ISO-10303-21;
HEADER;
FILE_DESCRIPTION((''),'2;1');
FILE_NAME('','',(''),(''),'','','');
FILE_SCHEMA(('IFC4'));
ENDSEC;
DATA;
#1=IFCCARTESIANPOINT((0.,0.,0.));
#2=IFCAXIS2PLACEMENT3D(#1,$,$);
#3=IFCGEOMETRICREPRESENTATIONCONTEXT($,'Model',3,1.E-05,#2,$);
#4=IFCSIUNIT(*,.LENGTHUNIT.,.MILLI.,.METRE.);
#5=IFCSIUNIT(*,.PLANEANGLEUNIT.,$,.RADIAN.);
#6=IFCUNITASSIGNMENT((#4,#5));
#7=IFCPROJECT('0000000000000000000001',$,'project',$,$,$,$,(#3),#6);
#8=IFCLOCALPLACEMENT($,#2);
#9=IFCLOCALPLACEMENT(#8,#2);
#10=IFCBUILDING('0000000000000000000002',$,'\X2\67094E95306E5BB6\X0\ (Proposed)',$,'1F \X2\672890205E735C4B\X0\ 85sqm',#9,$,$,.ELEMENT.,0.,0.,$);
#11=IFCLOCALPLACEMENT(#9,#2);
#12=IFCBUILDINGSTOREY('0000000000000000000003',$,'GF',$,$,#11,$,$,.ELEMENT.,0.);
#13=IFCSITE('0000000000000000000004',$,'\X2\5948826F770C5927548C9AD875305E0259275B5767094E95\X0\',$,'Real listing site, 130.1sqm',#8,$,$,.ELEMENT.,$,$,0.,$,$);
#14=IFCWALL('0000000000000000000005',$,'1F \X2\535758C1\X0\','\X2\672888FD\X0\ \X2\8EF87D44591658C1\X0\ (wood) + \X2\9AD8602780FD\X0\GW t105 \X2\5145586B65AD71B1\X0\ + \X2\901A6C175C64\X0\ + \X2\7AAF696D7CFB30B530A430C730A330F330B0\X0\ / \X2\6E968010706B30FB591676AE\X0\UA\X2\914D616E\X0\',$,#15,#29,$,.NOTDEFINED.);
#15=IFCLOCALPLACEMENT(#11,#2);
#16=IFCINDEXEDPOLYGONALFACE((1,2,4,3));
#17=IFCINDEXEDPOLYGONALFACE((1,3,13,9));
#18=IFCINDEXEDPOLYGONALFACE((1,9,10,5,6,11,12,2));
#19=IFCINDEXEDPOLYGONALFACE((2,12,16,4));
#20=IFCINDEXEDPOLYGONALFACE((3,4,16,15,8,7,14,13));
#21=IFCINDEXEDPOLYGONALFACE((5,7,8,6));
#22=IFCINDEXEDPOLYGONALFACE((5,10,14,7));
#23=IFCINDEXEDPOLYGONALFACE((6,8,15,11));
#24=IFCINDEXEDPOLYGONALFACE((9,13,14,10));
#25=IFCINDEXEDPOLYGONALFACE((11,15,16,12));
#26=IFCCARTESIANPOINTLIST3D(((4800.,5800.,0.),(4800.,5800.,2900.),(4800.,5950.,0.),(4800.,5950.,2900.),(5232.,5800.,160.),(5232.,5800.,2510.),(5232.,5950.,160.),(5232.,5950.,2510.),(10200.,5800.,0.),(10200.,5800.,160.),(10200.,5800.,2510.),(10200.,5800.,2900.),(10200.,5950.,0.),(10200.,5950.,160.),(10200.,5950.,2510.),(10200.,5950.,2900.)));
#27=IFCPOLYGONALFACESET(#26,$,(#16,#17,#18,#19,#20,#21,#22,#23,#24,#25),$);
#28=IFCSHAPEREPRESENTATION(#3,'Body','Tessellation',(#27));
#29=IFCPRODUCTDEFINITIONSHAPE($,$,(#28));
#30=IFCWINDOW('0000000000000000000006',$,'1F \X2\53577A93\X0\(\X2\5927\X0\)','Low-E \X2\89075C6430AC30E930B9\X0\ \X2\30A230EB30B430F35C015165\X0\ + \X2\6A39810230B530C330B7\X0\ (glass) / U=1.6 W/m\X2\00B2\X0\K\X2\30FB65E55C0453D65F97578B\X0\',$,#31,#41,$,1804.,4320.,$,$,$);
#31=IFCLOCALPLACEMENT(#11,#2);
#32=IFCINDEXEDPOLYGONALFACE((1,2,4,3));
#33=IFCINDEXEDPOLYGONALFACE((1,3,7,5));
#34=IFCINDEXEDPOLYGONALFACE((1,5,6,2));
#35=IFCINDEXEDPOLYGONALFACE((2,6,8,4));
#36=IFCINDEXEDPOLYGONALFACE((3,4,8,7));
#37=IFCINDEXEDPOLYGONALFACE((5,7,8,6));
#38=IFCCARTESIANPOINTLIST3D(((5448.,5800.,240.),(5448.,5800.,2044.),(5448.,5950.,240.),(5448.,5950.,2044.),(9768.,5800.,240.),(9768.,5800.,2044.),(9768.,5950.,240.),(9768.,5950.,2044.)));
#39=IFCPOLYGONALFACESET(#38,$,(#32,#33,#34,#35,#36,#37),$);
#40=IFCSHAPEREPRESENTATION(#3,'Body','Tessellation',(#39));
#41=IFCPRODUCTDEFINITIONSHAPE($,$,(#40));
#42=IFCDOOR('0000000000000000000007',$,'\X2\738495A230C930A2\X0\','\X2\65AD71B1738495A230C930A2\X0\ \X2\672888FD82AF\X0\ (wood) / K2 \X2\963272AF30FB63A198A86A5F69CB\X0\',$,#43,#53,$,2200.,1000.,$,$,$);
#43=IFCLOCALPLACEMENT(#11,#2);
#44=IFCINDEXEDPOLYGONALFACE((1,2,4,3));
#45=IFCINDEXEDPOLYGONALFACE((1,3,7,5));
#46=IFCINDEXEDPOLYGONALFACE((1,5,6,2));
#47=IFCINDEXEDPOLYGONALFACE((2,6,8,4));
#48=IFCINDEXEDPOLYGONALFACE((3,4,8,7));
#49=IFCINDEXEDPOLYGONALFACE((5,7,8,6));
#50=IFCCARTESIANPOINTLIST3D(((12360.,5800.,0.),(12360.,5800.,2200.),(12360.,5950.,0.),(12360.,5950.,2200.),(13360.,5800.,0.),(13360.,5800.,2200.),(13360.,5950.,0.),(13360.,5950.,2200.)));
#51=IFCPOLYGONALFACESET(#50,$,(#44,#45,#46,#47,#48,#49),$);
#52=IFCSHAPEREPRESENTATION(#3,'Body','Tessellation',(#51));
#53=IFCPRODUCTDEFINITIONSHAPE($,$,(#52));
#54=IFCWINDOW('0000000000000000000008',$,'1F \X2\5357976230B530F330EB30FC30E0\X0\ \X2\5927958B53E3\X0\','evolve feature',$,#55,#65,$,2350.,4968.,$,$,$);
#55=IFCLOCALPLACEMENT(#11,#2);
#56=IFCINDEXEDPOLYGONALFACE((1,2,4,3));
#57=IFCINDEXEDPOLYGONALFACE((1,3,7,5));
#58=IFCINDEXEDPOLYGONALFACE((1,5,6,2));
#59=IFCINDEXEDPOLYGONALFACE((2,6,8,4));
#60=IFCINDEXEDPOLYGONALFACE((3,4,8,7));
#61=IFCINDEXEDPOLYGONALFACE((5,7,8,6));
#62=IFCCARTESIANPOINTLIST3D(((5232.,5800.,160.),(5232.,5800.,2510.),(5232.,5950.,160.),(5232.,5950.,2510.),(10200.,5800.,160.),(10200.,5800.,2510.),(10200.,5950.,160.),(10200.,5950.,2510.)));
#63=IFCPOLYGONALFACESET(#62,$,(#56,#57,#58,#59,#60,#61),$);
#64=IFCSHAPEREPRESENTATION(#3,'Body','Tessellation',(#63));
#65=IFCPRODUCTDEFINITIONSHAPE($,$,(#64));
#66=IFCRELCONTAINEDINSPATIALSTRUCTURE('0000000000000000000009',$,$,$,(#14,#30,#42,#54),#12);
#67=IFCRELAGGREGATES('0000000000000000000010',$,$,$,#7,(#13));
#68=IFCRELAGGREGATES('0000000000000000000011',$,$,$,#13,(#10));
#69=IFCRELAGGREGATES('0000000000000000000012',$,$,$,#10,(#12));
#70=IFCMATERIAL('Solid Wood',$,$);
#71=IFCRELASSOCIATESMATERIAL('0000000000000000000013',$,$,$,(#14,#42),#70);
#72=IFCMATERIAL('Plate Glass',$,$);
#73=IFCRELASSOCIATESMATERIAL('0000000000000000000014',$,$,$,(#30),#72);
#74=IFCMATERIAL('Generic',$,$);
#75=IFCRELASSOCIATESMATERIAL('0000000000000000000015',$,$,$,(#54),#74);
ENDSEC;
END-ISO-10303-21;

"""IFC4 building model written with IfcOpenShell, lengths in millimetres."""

from ifc_helpers import new_model, si_unit, frame, frame_2d, origin, place, context, project, spatial, rectangle, extrude, material, element, fill, save


model = new_model("IFC4")

# Units and contexts
model_context = context("Model", 3, precision=1e-05, world=origin())
ifc_project = project(units=[si_unit("LENGTHUNIT", "METRE", prefix="MILLI"), si_unit("PLANEANGLEUNIT", "RADIAN")], contexts=[model_context])

# Site, building, storey
site_placement = place(None, origin())
site = spatial("IfcSite", under=ifc_project, at=site_placement, Name="奈良県大和高田市大字有井", ObjectType="Real listing site, 130.1sqm", CompositionType="ELEMENT", RefElevation=0.0)
building_placement = place(site_placement, origin())
building = spatial("IfcBuilding", under=site, at=building_placement, Name="有井の家 (Proposed)", ObjectType="1F 木造平屋 85sqm", CompositionType="ELEMENT", ElevationOfRefHeight=0.0, ElevationOfTerrain=0.0)
storey_placement = place(building_placement, origin())
storey = spatial("IfcBuildingStorey", under=building, at=storey_placement, Name="GF", CompositionType="ELEMENT", Elevation=0.0)

# Shared definitions
ifc_material_1 = material(Name="Solid Wood")
ifc_material_2 = material(Name="Generic")

# Wall, openings, windows, door
wall_1_placement = place(storey_placement, frame((2400.0, 2900.0, 0.0)))
wall_1 = element("IfcWall", 1, at=wall_1_placement, inside=storey, material=ifc_material_1, Name="1F 南壁", Description="木製 軸組外壁 (wood) + 高性能GW t105 充填断熱 + 通気層 + 窯業系サイディング / 準耐火・外皮UA配慮", PredefinedType="NOTDEFINED", context=model_context, shape_type="SweptSolid", body=[
    extrude(rectangle(XDim=5400.0, YDim=150.0, at=frame_2d((2700.0, 75.0))), frame((2400.0, 2900.0, 0.0)), (0.0, 0.0, 1.0), 2900.0),
])
opening_1_placement = place(storey_placement, frame((2724.0, 2900.0, 120.0)))
opening_1 = element("IfcOpeningElement", 2, at=opening_1_placement, cuts=wall_1, PredefinedType="NOTDEFINED", context=model_context, shape_type="SweptSolid", body=[
    extrude(rectangle(XDim=4320.0, YDim=150.0, at=frame_2d((2160.0, 75.0))), frame((2724.0, 2900.0, 120.0)), (0.0, 0.0, 1.0), 1804.0),
])
opening_2_placement = place(storey_placement, frame((6180.0, 2900.0, 0.0)))
opening_2 = element("IfcOpeningElement", 3, at=opening_2_placement, cuts=wall_1, PredefinedType="NOTDEFINED", context=model_context, shape_type="SweptSolid", body=[
    extrude(rectangle(XDim=1000.0, YDim=150.0, at=frame_2d((500.0, 75.0))), frame((6180.0, 2900.0, 0.0)), (0.0, 0.0, 1.0), 2200.0),
])
opening_3_placement = place(storey_placement, frame((2616.0, 2900.0, 80.0)))
opening_3 = element("IfcOpeningElement", 4, at=opening_3_placement, cuts=wall_1, PredefinedType="NOTDEFINED", context=model_context, shape_type="SweptSolid", body=[
    extrude(rectangle(XDim=4968.0, YDim=150.0, at=frame_2d((2484.0, 75.0))), frame((2616.0, 2900.0, 80.0)), (0.0, 0.0, 1.0), 2350.0),
])
ifc_material_3 = material(Name="Plate Glass")
window_1_placement = place(storey_placement, frame((2724.0, 2900.0, 120.0)))
window_1 = element("IfcWindow", 5, at=window_1_placement, inside=storey, material=ifc_material_3, Name="1F 南窓(大)", Description="Low-E 複層ガラス アルゴン封入 + 樹脂サッシ (glass) / U=1.6 W/m²K・日射取得型", OverallHeight=1804.0, OverallWidth=4320.0, context=model_context, shape_type="SweptSolid", body=[
    extrude(rectangle(XDim=4320.0, YDim=150.0, at=frame_2d((2160.0, 75.0))), frame((2724.0, 2900.0, 120.0)), (0.0, 0.0, 1.0), 1804.0),
])
fill(opening_1, window_1)
door_1_placement = place(storey_placement, frame((6180.0, 2900.0, 0.0)))
door_1 = element("IfcDoor", 6, at=door_1_placement, inside=storey, material=ifc_material_1, Name="玄関ドア", Description="断熱玄関ドア 木製芯 (wood) / K2 防犯・採風機構", OverallHeight=2200.0, OverallWidth=1000.0, context=model_context, shape_type="SweptSolid", body=[
    extrude(rectangle(XDim=1000.0, YDim=150.0, at=frame_2d((500.0, 75.0))), frame((6180.0, 2900.0, 0.0)), (0.0, 0.0, 1.0), 2200.0),
])
fill(opening_2, door_1)
window_2_placement = place(storey_placement, frame((2616.0, 2900.0, 80.0)))
window_2 = element("IfcWindow", 7, at=window_2_placement, inside=storey, material=ifc_material_2, Name="1F 南面サンルーム 大開口", Description="evolve feature", OverallHeight=2350.0, OverallWidth=4968.0, context=model_context, shape_type="SweptSolid", body=[
    extrude(rectangle(XDim=4968.0, YDim=150.0, at=frame_2d((2484.0, 75.0))), frame((2616.0, 2900.0, 80.0)), (0.0, 0.0, 1.0), 2350.0),
])
fill(opening_3, window_2)

save(model, "model.ifc")
